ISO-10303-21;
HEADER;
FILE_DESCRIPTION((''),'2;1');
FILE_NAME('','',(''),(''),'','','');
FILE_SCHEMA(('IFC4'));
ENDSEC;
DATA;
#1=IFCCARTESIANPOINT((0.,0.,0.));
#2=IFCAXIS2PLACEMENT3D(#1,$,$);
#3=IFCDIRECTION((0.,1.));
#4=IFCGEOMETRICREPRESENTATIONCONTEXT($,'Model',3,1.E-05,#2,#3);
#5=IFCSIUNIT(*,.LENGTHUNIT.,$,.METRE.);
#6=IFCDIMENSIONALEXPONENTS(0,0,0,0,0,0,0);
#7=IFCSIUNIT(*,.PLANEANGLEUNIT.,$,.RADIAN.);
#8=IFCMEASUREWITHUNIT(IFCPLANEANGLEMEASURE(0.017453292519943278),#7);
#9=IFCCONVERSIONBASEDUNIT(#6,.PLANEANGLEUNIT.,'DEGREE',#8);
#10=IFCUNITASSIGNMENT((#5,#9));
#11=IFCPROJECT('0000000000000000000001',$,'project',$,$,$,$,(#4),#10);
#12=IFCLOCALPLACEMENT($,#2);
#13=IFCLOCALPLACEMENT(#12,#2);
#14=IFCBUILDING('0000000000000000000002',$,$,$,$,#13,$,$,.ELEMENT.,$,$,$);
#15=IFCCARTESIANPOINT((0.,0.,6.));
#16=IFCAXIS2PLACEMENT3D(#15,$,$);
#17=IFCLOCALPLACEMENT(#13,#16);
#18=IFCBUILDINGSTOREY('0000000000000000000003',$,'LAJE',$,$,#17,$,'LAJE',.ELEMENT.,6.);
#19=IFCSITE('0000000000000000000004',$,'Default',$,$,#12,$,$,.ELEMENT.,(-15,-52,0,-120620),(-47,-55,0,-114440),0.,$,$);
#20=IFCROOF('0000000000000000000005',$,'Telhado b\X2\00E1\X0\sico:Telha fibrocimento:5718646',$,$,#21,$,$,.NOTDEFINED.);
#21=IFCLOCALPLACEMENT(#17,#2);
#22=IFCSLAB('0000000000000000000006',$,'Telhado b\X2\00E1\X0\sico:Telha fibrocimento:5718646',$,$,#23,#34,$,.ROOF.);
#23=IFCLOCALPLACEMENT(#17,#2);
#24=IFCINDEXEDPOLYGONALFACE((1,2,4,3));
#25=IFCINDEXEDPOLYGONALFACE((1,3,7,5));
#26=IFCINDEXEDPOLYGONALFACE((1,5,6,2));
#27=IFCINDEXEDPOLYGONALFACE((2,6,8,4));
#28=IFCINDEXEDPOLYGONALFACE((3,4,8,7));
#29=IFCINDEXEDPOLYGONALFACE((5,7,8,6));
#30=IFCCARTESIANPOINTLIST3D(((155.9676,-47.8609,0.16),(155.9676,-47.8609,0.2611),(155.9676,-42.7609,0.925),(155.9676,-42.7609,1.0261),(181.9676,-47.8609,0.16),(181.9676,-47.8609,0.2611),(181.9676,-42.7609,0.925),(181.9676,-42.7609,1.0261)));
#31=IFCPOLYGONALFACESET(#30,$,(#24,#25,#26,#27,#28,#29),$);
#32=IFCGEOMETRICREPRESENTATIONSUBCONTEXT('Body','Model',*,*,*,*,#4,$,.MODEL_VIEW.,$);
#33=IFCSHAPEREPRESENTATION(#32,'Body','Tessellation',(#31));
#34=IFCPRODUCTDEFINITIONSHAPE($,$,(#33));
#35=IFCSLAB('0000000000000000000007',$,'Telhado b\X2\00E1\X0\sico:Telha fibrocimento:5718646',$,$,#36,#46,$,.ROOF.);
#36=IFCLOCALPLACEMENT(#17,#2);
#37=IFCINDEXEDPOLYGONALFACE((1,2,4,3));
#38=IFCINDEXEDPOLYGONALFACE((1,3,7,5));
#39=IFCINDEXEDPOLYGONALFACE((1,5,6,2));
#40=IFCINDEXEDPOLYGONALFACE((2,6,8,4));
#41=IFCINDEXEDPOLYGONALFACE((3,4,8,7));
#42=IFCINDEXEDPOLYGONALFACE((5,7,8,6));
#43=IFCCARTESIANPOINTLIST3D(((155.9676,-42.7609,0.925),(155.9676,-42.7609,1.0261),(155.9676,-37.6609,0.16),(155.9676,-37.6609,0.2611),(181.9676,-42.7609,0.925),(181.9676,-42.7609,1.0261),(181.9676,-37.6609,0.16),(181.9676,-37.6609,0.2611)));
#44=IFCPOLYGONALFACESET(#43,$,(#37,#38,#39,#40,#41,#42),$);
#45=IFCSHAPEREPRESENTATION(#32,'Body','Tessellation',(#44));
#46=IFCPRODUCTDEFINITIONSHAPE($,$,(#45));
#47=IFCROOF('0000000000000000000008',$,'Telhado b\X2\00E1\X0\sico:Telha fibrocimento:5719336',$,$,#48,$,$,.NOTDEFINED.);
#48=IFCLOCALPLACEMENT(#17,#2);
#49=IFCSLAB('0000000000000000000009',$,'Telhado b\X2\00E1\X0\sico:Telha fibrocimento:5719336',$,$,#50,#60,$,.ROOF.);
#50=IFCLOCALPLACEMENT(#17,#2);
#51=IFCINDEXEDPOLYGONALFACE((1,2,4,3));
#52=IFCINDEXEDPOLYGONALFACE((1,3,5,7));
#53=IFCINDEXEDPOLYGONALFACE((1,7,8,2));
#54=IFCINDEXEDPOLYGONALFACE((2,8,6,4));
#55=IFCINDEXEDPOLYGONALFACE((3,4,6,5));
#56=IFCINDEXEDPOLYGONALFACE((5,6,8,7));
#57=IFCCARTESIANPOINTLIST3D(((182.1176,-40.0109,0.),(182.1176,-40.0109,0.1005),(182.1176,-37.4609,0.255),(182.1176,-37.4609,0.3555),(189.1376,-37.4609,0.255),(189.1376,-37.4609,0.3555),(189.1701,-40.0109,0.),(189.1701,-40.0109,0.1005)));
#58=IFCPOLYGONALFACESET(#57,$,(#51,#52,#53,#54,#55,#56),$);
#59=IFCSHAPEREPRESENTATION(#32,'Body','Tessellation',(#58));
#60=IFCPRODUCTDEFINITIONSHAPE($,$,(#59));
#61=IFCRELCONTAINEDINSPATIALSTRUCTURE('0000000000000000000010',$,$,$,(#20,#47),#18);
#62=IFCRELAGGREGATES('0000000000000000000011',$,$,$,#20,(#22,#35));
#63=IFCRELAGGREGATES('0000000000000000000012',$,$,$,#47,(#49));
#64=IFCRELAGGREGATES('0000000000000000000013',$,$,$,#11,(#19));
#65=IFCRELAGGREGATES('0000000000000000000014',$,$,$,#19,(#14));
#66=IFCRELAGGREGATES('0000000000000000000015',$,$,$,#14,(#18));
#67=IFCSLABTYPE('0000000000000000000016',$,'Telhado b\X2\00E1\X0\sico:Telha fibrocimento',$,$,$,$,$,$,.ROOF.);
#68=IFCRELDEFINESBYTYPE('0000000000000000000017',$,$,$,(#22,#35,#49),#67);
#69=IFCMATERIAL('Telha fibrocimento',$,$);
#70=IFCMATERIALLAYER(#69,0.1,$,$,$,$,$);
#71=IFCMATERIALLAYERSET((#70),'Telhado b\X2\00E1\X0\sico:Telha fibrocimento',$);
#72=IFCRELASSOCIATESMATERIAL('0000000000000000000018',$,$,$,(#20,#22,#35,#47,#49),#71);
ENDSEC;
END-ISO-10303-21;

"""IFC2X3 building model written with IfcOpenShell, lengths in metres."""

from ifc_helpers import new_model, entity, si_unit, converted_unit, direction, frame, frame_2d, origin, place, context, subcontext, project, spatial, polyline, rectangle, outline, extrude, material, layer, layer_set, type_object, element, aggregate, save


model = new_model("IFC2X3")

# Units and contexts
model_context = context("Model", 3, precision=1e-05, world=origin(), true_north=direction((0.0, 1.0)))
body_context = subcontext(model_context, "Body", "Model", "MODEL_VIEW")
ifc_project = project(units=[si_unit("LENGTHUNIT", "METRE"), converted_unit("PLANEANGLEUNIT", "DEGREE", entity("IfcPlaneAngleMeasure", 0.017453292519943278), si_unit("PLANEANGLEUNIT", "RADIAN"), dimensions=[0, 0, 0, 0, 0, 0, 0])], contexts=[model_context])

# Site, building, storey
site_placement = place(None, origin())
site = spatial("IfcSite", under=ifc_project, at=site_placement, Name="Default", CompositionType="ELEMENT", RefLatitude=(-15, -52, 0, -120620), RefLongitude=(-47, -55, 0, -114440), RefElevation=0.0)
building_placement = place(site_placement, origin())
building = spatial("IfcBuilding", under=site, at=building_placement, CompositionType="ELEMENT")
storey_placement = place(building_placement, frame((0.0, 0.0, 6.0)))
storey = spatial("IfcBuildingStorey", under=building, at=storey_placement, Name="LAJE", LongName="LAJE", CompositionType="ELEMENT", Elevation=6.0)

# Roof, slabs
ifc_material = material(Name="Telha fibrocimento")
ifc_layer = layer(ifc_material, 0.1)
ifc_layer_set = layer_set([ifc_layer], Name="Telhado básico:Telha fibrocimento")
roof_1_placement = place(storey_placement, frame((155.9676, -47.8609, 0.16)))
roof_1 = element("IfcRoof", 1, at=roof_1_placement, inside=storey, material=ifc_layer_set, Name="Telhado básico:Telha fibrocimento:5718646", ShapeType="NOTDEFINED")
slab_type = type_object("IfcSlabType", Name="Telhado básico:Telha fibrocimento", PredefinedType="ROOF")
slab_1_placement = place(roof_1_placement, origin())
slab_1 = element("IfcSlab", 2, at=slab_1_placement, type_object=slab_type, material=ifc_layer_set, Name="Telhado básico:Telha fibrocimento:5718646", PredefinedType="ROOF", context=body_context, shape_type="SweptSolid", body=[
    extrude(rectangle(XDim=26.0, YDim=5.1571, at=frame_2d((0.0, 0.0), x_axis=(-1.0, 0.0))), frame((13.0, 2.55, 0.3825), z_axis=(0.0, -0.14834, 0.988936), x_axis=(1.0, 0.0, 0.0)), (0.0, 0.14834, 0.988936), 0.1011),
])
slab_2_placement = place(roof_1_placement, origin())
slab_2 = element("IfcSlab", 3, at=slab_2_placement, type_object=slab_type, material=ifc_layer_set, Name="Telhado básico:Telha fibrocimento:5718646", PredefinedType="ROOF", context=body_context, shape_type="SweptSolid", body=[
    extrude(rectangle(XDim=5.1571, YDim=26.0, at=frame_2d((0.0, 0.0), x_axis=(0.0, -1.0))), frame((13.0, 7.65, 0.3825), z_axis=(0.0, 0.14834, 0.988936), x_axis=(1.0, 0.0, 0.0)), (0.0, -0.14834, 0.988936), 0.1011),
])
aggregate(roof_1, [slab_1, slab_2])

# Roof, slab
roof_2_placement = place(storey_placement, frame((182.1176, -40.0109, 0.0)))
roof_2 = element("IfcRoof", 4, at=roof_2_placement, inside=storey, material=ifc_layer_set, Name="Telhado básico:Telha fibrocimento:5719336", ShapeType="NOTDEFINED")
slab_3_placement = place(roof_2_placement, origin())
slab_3 = element("IfcSlab", 5, at=slab_3_placement, type_object=slab_type, material=ifc_layer_set, Name="Telhado básico:Telha fibrocimento:5719336", PredefinedType="ROOF", context=body_context, shape_type="SweptSolid", body=[
    extrude(outline(polyline([(-3.5263, 1.2814), (-3.5263, -1.2814), (3.5263, -1.2814), (3.4937, 1.2814), (-3.5263, 1.2814)])), frame((3.5263, 1.275, 0.1275), z_axis=(0.0, -0.099504, 0.995037), x_axis=(1.0, 0.0, 0.0)), (0.0, 0.099504, 0.995037), 0.1005),
])
aggregate(roof_2, [slab_3])

save(model, "model.ifc")
